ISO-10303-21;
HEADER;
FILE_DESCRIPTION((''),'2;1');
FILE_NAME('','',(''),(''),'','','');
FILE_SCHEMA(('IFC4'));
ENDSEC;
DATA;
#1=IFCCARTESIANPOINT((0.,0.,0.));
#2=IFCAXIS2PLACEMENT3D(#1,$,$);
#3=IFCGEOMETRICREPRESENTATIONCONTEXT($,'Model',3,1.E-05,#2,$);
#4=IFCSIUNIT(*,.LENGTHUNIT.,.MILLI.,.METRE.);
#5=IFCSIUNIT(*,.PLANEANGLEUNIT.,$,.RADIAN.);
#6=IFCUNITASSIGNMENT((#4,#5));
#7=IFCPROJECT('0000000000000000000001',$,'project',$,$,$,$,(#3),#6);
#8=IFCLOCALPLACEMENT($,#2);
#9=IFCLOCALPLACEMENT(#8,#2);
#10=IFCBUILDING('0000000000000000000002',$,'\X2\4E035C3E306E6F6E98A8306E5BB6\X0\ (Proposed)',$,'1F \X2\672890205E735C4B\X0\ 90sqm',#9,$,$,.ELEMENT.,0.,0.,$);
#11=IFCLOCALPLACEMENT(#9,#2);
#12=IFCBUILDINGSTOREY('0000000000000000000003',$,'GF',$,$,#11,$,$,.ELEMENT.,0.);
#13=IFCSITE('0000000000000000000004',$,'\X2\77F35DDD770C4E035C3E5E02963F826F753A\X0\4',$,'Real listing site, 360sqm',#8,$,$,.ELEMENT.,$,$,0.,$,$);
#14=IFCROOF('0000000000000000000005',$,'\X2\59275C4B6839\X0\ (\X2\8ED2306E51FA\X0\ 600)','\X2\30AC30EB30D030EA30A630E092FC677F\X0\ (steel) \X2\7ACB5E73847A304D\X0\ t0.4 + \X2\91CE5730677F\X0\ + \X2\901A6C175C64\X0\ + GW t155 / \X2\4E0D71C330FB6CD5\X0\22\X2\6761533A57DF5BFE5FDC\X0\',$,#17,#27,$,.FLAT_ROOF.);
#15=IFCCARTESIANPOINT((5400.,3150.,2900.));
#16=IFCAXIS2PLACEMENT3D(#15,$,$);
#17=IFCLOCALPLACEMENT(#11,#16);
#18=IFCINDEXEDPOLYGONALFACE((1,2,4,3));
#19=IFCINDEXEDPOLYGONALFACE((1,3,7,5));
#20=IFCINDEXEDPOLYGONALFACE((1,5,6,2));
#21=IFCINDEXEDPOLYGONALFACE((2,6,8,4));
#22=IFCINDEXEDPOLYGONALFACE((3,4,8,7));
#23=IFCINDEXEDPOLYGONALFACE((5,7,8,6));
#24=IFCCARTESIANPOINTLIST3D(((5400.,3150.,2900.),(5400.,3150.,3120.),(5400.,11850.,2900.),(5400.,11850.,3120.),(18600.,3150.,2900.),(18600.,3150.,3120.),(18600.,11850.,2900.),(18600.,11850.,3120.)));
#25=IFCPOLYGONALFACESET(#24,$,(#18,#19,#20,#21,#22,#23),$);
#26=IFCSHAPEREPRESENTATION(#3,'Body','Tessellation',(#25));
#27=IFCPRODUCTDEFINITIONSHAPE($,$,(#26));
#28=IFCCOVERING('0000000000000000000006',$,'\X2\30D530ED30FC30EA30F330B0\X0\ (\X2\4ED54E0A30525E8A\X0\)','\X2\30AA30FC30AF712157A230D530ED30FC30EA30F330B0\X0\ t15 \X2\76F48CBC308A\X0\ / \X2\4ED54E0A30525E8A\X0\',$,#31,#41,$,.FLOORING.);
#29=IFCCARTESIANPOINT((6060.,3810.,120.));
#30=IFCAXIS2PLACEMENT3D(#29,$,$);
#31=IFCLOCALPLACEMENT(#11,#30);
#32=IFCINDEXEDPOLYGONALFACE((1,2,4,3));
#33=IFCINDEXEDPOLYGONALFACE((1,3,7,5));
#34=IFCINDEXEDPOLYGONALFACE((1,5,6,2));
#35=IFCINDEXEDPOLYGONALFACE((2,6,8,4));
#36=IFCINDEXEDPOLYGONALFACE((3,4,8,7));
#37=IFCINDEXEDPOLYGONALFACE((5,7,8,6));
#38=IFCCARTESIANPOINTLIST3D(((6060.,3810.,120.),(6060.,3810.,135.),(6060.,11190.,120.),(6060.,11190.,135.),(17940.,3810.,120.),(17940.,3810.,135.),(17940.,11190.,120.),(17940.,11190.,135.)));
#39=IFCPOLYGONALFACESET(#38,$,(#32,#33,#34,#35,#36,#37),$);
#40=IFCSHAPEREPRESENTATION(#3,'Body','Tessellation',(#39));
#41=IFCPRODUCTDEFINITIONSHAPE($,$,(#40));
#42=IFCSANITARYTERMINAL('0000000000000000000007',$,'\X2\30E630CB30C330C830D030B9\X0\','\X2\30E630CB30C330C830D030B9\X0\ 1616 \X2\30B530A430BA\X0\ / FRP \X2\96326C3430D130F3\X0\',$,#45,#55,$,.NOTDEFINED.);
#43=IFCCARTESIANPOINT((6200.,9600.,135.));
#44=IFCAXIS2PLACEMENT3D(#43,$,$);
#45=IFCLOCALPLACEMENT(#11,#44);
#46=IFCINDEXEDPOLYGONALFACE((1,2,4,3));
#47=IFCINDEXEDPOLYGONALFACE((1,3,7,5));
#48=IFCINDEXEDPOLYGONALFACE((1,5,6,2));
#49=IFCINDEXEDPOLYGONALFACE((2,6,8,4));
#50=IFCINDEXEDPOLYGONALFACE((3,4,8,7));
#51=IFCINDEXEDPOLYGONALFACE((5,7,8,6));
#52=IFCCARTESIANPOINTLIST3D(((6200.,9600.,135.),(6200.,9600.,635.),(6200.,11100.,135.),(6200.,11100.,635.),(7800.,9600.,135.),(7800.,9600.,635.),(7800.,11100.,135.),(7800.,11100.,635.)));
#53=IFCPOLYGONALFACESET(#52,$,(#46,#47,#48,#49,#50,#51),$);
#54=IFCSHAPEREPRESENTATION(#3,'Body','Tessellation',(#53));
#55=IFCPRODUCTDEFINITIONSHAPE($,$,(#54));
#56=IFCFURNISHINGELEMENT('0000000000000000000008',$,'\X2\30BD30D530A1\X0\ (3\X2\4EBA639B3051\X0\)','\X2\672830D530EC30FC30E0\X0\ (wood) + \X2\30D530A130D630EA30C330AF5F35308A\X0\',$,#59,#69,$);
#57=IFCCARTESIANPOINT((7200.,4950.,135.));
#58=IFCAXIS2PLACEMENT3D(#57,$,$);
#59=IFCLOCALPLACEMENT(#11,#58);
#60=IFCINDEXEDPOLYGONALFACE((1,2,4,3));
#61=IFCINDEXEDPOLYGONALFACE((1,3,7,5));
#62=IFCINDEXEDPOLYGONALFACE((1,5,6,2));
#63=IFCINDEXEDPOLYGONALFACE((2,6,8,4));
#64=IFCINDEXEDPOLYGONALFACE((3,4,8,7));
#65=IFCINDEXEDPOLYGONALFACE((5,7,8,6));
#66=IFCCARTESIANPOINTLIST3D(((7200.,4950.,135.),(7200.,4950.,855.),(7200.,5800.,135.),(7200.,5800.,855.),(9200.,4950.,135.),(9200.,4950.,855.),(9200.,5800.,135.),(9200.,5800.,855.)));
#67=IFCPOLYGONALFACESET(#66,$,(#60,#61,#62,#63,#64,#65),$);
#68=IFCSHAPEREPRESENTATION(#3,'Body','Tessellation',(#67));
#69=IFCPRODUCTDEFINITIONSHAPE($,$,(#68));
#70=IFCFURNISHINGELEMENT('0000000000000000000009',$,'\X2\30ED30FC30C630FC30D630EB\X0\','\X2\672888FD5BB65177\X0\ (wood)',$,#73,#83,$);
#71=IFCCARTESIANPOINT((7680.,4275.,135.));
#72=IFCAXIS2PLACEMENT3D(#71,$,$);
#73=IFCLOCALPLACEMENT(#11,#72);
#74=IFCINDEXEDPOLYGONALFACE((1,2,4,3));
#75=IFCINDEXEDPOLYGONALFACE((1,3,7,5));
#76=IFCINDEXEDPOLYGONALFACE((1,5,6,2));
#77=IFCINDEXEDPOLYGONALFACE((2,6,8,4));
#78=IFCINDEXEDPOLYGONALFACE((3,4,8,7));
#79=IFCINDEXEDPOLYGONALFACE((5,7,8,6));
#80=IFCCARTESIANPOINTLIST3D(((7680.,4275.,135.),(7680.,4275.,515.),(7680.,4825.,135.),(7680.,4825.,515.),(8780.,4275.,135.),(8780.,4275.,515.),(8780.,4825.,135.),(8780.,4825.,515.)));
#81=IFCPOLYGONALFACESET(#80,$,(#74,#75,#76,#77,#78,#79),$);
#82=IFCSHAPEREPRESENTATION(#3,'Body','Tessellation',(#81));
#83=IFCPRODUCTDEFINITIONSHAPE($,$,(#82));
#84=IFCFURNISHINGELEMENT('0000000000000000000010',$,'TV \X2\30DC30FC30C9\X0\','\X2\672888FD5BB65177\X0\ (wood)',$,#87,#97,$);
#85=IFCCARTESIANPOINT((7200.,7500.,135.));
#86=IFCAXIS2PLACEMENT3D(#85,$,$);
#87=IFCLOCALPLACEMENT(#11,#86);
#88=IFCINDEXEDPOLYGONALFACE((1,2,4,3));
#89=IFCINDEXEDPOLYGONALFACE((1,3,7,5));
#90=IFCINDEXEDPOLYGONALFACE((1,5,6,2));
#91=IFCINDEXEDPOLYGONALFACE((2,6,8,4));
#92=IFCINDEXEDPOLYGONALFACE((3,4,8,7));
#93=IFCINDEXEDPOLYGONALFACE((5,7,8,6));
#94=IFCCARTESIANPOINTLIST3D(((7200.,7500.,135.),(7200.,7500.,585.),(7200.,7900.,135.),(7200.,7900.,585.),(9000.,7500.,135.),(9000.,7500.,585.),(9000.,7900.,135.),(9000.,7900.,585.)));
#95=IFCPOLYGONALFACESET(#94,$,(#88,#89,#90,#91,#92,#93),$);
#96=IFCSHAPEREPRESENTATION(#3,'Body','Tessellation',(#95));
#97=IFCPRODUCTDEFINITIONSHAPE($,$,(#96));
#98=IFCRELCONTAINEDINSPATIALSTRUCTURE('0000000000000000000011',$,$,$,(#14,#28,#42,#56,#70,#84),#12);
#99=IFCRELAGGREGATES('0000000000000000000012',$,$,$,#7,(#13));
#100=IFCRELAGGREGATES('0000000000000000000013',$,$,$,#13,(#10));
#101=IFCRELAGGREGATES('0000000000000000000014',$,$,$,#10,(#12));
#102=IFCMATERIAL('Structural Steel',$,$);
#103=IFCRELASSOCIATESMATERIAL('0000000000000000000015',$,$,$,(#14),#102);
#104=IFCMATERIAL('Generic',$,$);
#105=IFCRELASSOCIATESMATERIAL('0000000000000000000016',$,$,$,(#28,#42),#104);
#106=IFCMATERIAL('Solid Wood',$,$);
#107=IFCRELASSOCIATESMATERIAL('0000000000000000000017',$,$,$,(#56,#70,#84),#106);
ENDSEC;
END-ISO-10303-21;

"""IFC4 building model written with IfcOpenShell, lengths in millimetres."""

from ifc_helpers import new_model, si_unit, frame, frame_2d, origin, place, context, project, spatial, rectangle, extrude, material, element, save


model = new_model("IFC4")

# Units and contexts
model_context = context("Model", 3, precision=1e-05, world=origin())
ifc_project = project(units=[si_unit("LENGTHUNIT", "METRE", prefix="MILLI"), si_unit("PLANEANGLEUNIT", "RADIAN")], contexts=[model_context])

# Site, building, storey
site_placement = place(None, origin())
site = spatial("IfcSite", under=ifc_project, at=site_placement, Name="石川県七尾市阿良町4", ObjectType="Real listing site, 360sqm", CompositionType="ELEMENT", RefElevation=0.0)
building_placement = place(site_placement, origin())
building = spatial("IfcBuilding", under=site, at=building_placement, Name="七尾の潮風の家 (Proposed)", ObjectType="1F 木造平屋 90sqm", CompositionType="ELEMENT", ElevationOfRefHeight=0.0, ElevationOfTerrain=0.0)
storey_placement = place(building_placement, origin())
storey = spatial("IfcBuildingStorey", under=building, at=storey_placement, Name="GF", CompositionType="ELEMENT", Elevation=0.0)

# Shared definitions
ifc_material_1 = material(Name="Solid Wood")

# Roof
ifc_material_2 = material(Name="Structural Steel")
roof_placement = place(storey_placement, frame((5400.0, 3150.0, 2900.0)))
element("IfcRoof", 1, at=roof_placement, inside=storey, material=ifc_material_2, Name="大屋根 (軒の出 600)", Description="ガルバリウム鋼板 (steel) 立平葺き t0.4 + 野地板 + 通気層 + GW t155 / 不燃・法22条区域対応", PredefinedType="FLAT_ROOF", context=model_context, shape_type="SweptSolid", body=[
    extrude(rectangle(XDim=13200.0, YDim=8700.0, at=frame_2d((6600.0, 4350.0))), frame((5400.0, 3150.0, 2900.0)), (0.0, 0.0, 1.0), 220.0),
])

# Covering
ifc_material_3 = material(Name="Generic")
covering_placement = place(storey_placement, frame((6060.0, 3810.0, 120.0)))
element("IfcCovering", 2, at=covering_placement, inside=storey, material=ifc_material_3, Name="フローリング (仕上げ床)", Description="オーク無垢フローリング t15 直貼り / 仕上げ床", PredefinedType="FLOORING", context=model_context, shape_type="SweptSolid", body=[
    extrude(rectangle(XDim=11880.0, YDim=7380.0, at=frame_2d((5940.0, 3690.0))), frame((6060.0, 3810.0, 120.0)), (0.0, 0.0, 1.0), 15.0),
])

# Sanitary terminal
sanitary_terminal_placement = place(storey_placement, frame((6200.0, 9600.0, 135.0)))
element("IfcSanitaryTerminal", 3, at=sanitary_terminal_placement, inside=storey, material=ifc_material_3, Name="ユニットバス", Description="ユニットバス 1616 サイズ / FRP 防水パン", PredefinedType="NOTDEFINED", context=model_context, shape_type="SweptSolid", body=[
    extrude(rectangle(XDim=1600.0, YDim=1500.0, at=frame_2d((800.0, 750.0))), frame((6200.0, 9600.0, 135.0)), (0.0, 0.0, 1.0), 500.0),
])

# Furnishing elements
furnishing_1_placement = place(storey_placement, frame((7200.0, 4950.0, 135.0)))
element("IfcFurnishingElement", 4, at=furnishing_1_placement, inside=storey, material=ifc_material_1, Name="ソファ (3人掛け)", Description="木フレーム (wood) + ファブリック張り", context=model_context, shape_type="SweptSolid", body=[
    extrude(rectangle(XDim=2000.0, YDim=850.0, at=frame_2d((1000.0, 425.0))), frame((7200.0, 4950.0, 135.0)), (0.0, 0.0, 1.0), 720.0),
])
furnishing_2_placement = place(storey_placement, frame((7680.0, 4275.0, 135.0)))
element("IfcFurnishingElement", 5, at=furnishing_2_placement, inside=storey, material=ifc_material_1, Name="ローテーブル", Description="木製家具 (wood)", context=model_context, shape_type="SweptSolid", body=[
    extrude(rectangle(XDim=1100.0, YDim=550.0, at=frame_2d((550.0, 275.0))), frame((7680.0, 4275.0, 135.0)), (0.0, 0.0, 1.0), 380.0),
])
furnishing_3_placement = place(storey_placement, frame((7200.0, 7500.0, 135.0)))
element("IfcFurnishingElement", 6, at=furnishing_3_placement, inside=storey, material=ifc_material_1, Name="TV ボード", Description="木製家具 (wood)", context=model_context, shape_type="SweptSolid", body=[
    extrude(rectangle(XDim=1800.0, YDim=400.0, at=frame_2d((900.0, 200.0))), frame((7200.0, 7500.0, 135.0)), (0.0, 0.0, 1.0), 450.0),
])

save(model, "model.ifc")
